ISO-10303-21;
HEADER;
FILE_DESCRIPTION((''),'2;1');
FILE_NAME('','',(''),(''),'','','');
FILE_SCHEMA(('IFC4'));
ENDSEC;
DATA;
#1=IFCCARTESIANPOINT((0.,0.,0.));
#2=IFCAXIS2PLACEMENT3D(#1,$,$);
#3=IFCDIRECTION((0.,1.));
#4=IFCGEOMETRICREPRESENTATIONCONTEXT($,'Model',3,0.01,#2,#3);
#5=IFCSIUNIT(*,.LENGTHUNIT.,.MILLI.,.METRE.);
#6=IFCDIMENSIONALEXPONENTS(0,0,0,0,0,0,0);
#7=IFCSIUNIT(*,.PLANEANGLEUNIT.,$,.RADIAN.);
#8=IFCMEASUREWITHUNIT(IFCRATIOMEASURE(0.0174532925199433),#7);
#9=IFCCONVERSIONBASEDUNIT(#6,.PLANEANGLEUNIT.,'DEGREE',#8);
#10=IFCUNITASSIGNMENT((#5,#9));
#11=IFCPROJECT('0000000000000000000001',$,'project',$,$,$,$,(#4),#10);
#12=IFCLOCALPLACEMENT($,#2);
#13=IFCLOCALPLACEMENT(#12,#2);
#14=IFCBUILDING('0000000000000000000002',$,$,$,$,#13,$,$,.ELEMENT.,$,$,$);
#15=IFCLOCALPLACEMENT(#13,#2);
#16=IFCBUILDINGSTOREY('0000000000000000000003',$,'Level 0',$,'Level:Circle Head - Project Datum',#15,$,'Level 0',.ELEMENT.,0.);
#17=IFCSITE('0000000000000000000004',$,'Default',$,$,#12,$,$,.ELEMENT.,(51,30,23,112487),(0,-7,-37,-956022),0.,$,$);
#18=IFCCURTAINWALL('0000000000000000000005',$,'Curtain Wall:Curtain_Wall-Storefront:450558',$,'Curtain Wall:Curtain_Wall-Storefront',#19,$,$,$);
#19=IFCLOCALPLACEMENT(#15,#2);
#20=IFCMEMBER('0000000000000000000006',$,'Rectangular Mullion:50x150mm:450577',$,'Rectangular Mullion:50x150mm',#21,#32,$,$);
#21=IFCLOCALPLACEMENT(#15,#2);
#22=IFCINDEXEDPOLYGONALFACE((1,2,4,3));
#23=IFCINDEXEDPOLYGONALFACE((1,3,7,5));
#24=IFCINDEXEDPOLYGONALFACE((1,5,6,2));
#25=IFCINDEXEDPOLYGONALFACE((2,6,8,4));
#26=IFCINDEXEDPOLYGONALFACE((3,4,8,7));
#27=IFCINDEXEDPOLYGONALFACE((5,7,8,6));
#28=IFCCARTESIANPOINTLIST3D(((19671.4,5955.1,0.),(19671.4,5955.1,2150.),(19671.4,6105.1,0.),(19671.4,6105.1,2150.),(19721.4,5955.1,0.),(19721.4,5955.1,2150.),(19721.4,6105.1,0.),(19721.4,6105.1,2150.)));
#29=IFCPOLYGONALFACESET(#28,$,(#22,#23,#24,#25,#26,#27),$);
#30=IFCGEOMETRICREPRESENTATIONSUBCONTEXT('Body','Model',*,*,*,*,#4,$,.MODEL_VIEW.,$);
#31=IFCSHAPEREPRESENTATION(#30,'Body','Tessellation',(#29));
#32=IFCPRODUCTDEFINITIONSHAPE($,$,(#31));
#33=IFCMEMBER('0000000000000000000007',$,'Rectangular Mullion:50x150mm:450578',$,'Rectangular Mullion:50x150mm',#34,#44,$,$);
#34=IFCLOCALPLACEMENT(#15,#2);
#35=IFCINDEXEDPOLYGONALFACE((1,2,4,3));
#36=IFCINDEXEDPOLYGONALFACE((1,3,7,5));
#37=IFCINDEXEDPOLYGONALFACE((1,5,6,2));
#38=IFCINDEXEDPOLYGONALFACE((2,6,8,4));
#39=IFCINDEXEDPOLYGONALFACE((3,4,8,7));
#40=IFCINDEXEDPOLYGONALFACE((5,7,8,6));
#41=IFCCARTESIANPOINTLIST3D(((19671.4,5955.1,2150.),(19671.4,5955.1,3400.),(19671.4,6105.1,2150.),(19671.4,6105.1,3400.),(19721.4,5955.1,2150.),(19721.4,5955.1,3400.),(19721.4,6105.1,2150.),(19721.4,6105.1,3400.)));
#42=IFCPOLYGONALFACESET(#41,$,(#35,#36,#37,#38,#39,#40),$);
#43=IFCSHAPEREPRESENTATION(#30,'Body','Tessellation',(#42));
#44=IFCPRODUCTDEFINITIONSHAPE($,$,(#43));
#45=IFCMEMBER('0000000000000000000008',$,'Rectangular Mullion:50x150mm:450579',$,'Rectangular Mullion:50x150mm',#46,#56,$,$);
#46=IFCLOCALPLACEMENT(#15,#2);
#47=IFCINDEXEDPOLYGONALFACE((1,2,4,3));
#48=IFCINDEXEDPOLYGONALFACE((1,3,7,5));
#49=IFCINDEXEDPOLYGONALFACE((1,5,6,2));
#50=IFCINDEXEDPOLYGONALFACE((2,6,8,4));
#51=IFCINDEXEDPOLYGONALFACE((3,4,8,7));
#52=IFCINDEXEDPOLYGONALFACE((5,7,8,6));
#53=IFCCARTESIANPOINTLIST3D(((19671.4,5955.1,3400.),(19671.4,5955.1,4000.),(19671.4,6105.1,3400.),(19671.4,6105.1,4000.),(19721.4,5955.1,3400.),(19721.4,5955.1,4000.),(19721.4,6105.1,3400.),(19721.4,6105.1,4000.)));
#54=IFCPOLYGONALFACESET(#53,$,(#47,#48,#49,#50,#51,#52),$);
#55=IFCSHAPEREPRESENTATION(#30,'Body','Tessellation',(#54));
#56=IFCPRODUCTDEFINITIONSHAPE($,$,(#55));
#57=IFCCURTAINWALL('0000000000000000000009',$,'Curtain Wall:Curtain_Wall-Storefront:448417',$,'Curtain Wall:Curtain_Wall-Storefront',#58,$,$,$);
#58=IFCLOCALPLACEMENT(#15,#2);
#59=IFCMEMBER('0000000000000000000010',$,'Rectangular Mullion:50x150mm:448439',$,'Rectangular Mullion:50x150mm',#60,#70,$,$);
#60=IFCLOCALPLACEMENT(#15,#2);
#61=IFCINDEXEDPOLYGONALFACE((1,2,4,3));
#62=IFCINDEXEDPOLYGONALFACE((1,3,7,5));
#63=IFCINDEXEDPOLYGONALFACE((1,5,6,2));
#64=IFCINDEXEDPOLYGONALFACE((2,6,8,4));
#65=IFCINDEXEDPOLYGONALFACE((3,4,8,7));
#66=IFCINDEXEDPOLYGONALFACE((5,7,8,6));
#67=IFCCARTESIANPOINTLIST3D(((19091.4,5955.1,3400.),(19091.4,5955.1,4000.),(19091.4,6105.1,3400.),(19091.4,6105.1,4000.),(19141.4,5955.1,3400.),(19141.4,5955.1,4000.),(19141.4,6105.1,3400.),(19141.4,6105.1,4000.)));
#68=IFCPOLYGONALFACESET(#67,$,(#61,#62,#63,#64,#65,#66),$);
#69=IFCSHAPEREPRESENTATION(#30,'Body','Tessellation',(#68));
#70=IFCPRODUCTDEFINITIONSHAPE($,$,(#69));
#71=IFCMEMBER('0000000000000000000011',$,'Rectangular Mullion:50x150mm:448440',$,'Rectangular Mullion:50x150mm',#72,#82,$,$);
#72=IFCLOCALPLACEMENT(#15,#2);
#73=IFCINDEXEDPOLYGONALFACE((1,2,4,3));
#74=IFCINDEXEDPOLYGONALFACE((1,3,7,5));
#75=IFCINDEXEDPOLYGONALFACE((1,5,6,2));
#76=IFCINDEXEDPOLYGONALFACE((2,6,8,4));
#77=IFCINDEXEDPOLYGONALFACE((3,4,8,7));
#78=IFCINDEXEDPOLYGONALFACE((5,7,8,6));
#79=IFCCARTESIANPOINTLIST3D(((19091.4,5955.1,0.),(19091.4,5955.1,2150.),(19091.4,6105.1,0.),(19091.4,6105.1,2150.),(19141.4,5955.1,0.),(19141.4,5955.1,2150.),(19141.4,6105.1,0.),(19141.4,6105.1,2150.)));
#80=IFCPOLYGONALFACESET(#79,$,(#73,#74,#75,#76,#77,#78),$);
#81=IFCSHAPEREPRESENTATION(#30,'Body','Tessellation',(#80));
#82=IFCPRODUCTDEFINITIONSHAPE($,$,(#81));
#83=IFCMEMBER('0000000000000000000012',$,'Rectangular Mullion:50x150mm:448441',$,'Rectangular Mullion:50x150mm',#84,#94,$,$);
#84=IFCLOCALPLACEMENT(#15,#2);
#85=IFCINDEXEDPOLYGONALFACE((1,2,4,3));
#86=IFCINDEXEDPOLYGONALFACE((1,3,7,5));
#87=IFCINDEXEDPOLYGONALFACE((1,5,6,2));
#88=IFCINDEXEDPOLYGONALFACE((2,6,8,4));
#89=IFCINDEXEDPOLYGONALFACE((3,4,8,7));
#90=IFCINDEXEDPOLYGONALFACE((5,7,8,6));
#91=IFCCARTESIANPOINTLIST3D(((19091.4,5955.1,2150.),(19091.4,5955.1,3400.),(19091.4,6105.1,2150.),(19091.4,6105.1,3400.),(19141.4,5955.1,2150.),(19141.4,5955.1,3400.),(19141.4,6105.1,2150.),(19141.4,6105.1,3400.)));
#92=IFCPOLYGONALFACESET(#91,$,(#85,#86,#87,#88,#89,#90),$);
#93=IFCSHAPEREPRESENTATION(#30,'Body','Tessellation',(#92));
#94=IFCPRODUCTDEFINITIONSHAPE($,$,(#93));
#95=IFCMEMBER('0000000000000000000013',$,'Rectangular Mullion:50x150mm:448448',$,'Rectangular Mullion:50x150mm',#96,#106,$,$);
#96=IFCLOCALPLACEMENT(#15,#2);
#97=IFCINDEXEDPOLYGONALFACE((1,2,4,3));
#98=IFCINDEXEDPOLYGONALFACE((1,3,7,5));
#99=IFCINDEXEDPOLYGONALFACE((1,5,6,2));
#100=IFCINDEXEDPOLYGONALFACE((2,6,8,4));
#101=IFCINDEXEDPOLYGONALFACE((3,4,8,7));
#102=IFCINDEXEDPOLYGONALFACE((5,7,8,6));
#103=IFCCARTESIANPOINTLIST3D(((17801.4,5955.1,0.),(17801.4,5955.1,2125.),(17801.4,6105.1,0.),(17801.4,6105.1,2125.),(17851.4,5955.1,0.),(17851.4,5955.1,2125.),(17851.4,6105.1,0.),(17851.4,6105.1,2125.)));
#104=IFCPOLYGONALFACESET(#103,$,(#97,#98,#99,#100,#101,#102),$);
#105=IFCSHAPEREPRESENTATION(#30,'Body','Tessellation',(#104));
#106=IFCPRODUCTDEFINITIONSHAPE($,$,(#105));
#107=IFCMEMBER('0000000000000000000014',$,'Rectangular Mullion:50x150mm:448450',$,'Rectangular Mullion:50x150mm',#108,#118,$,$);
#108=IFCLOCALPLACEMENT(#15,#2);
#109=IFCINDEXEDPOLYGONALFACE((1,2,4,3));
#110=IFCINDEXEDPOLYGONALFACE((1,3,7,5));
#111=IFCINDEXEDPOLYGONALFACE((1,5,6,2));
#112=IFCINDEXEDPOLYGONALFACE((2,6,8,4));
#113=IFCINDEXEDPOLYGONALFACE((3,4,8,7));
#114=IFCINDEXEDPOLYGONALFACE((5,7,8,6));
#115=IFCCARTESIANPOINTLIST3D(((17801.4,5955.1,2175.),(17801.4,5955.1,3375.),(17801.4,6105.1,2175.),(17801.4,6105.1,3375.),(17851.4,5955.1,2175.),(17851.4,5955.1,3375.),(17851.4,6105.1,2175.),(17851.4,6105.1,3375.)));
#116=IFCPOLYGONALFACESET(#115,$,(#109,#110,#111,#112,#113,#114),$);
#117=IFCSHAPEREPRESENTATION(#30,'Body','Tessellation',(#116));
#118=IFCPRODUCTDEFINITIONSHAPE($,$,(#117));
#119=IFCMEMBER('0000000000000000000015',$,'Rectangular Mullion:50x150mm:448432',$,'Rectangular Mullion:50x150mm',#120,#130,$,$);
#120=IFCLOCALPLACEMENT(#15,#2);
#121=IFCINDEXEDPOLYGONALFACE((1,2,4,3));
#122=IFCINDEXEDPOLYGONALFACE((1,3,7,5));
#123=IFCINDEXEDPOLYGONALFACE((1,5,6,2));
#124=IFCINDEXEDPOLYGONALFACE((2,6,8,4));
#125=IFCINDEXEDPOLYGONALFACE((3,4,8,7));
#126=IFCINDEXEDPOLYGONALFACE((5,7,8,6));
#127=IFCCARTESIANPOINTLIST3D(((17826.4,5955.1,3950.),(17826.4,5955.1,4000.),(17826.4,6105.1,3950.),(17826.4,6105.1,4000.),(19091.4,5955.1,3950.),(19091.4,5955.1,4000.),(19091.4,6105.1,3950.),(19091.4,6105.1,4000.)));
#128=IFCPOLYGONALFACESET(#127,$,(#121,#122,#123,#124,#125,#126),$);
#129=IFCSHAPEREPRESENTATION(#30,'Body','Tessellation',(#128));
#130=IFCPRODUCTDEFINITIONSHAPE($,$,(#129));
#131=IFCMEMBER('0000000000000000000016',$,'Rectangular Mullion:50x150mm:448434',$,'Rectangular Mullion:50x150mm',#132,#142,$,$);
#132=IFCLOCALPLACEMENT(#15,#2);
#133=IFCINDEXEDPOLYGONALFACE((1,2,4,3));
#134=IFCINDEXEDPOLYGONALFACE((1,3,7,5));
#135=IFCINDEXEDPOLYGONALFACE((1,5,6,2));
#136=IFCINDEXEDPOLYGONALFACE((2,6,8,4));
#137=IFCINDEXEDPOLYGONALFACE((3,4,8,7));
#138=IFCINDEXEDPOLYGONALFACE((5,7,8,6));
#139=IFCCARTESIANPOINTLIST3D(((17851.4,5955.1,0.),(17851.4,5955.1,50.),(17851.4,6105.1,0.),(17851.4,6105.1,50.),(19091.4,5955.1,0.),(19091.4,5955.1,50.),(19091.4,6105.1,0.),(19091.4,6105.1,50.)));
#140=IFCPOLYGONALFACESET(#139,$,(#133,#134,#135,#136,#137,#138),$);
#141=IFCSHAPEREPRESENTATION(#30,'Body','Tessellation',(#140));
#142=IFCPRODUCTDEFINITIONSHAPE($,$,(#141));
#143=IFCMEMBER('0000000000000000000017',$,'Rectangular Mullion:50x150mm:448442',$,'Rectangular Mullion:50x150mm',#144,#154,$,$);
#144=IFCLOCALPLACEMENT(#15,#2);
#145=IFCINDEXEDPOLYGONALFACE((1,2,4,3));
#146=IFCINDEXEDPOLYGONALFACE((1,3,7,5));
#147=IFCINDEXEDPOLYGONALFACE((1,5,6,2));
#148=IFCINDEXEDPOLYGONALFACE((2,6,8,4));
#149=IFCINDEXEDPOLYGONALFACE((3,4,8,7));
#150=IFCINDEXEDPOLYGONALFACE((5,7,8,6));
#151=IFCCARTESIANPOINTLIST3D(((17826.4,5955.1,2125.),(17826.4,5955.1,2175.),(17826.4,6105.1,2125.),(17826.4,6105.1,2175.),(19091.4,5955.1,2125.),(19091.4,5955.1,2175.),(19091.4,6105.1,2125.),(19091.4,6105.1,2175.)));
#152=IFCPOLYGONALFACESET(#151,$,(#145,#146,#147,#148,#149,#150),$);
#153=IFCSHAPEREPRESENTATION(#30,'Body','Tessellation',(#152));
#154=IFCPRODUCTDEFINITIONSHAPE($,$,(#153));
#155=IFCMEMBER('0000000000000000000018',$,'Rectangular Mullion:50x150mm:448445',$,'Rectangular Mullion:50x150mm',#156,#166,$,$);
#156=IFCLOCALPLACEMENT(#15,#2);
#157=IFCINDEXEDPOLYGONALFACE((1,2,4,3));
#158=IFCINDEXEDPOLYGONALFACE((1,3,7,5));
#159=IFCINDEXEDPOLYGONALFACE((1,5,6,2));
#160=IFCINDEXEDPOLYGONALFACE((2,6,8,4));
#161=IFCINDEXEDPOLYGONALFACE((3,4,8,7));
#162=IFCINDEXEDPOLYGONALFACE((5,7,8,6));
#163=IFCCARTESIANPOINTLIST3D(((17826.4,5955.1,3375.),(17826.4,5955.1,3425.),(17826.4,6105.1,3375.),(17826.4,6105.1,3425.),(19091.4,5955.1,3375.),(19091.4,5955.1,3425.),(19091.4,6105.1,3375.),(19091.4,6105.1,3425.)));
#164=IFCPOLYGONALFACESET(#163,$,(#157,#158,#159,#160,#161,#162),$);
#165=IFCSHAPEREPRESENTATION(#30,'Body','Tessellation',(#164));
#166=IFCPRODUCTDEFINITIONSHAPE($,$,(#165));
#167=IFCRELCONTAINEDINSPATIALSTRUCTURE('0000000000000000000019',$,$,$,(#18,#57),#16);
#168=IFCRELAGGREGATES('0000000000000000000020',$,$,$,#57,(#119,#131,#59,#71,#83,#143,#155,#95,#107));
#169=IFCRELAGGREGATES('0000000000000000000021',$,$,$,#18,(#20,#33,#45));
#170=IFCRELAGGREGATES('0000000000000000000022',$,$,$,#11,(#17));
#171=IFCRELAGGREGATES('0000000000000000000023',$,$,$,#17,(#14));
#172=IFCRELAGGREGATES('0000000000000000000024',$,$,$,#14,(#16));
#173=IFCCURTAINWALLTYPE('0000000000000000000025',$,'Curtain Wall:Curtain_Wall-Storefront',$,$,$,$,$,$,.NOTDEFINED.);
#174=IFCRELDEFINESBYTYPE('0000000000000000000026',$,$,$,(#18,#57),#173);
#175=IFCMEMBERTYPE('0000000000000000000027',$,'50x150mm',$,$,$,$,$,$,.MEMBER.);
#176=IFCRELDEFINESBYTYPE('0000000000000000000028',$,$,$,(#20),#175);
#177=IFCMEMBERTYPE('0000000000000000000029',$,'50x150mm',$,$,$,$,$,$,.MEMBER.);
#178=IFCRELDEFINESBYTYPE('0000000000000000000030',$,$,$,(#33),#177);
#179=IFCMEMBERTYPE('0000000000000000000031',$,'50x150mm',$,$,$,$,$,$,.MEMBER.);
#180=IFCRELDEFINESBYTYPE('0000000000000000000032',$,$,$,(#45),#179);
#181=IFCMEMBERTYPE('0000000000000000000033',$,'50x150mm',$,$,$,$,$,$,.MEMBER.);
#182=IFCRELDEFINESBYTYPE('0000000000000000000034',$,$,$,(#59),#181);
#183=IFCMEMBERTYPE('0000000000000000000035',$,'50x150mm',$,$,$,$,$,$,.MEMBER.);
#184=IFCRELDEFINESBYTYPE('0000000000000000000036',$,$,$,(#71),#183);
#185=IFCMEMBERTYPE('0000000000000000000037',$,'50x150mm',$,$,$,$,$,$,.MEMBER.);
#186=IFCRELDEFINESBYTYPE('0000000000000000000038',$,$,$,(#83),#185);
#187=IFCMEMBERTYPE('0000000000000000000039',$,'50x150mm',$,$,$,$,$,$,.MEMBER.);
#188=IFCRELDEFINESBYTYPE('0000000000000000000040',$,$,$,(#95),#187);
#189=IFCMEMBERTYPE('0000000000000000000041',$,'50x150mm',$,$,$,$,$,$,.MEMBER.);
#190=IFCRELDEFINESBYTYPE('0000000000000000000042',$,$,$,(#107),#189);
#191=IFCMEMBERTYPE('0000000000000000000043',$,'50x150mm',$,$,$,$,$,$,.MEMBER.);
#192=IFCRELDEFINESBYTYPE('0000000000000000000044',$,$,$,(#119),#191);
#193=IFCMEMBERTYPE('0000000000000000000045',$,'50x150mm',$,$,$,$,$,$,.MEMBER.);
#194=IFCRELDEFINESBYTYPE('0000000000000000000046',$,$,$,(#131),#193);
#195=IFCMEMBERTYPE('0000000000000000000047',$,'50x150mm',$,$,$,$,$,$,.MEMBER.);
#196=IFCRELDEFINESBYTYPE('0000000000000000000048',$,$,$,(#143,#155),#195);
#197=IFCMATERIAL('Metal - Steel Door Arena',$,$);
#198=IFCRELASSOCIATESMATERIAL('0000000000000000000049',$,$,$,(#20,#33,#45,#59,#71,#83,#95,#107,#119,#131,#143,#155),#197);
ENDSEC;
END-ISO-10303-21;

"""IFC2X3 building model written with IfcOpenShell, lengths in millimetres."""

from ifc_helpers import new_model, entity, si_unit, converted_unit, direction, frame, origin, origin_2d_with_axis, place, context, subcontext, project, spatial, rectangle, extrude, source, transform, mapped, material, type_object, type_shapes, element, aggregate, save


model = new_model("IFC2X3")

# Units and contexts
model_context = context("Model", 3, precision=0.01, world=origin(), true_north=direction((0.0, 1.0)))
body_context = subcontext(model_context, "Body", "Model", "MODEL_VIEW")
ifc_project = project(units=[si_unit("LENGTHUNIT", "METRE", prefix="MILLI"), converted_unit("PLANEANGLEUNIT", "DEGREE", entity("IfcRatioMeasure", 0.0174532925199433), si_unit("PLANEANGLEUNIT", "RADIAN"), dimensions=[0, 0, 0, 0, 0, 0, 0])], contexts=[model_context])

# Site, building, storey
site_placement = place(None, origin())
site = spatial("IfcSite", under=ifc_project, at=site_placement, Name="Default", CompositionType="ELEMENT", RefLatitude=(51, 30, 23, 112487), RefLongitude=(0, -7, -37, -956022), RefElevation=0.0)
building_placement = place(site_placement, origin())
building = spatial("IfcBuilding", under=site, at=building_placement, CompositionType="ELEMENT")
storey_placement = place(building_placement, origin())
storey = spatial("IfcBuildingStorey", under=building, at=storey_placement, Name="Level 0", ObjectType="Level:Circle Head - Project Datum", LongName="Level 0", CompositionType="ELEMENT", Elevation=0.0)

# Curtain walls, members
curtain_wall_type = type_object("IfcCurtainWallType", Name="Curtain Wall:Curtain_Wall-Storefront", PredefinedType="NOTDEFINED")
curtain_wall_1_placement = place(storey_placement, origin())
curtain_wall_1 = element("IfcCurtainWall", 1, at=curtain_wall_1_placement, inside=storey, type_object=curtain_wall_type, Name="Curtain Wall:Curtain_Wall-Storefront:450558", ObjectType="Curtain Wall:Curtain_Wall-Storefront")
ifc_material_1 = material(Name="Metal - Steel Door Arena")
member_type_1 = type_object("IfcMemberType", Name="50x150mm", PredefinedType="MEMBER")
shared_shape_1 = source(origin(), body_context, "Body", "SweptSolid", [
    extrude(rectangle(XDim=150.0, YDim=50.0, at=origin_2d_with_axis()), frame((-25.0, 0.0, -2150.0), z_axis=(0.0, 0.0, 1.0), x_axis=(0.0, -1.0, 0.0)), (0.0, 0.0, 1.0), 2150.0),
])
type_shapes(member_type_1, [shared_shape_1])
member_1_placement = place(storey_placement, frame((19671.4, 6030.1, 0.0), z_axis=(0.0, 0.0, -1.0), x_axis=(-1.0, 0.0, 0.0)))
member_1 = element("IfcMember", 2, at=member_1_placement, type_object=member_type_1, material=ifc_material_1, Name="Rectangular Mullion:50x150mm:450577", ObjectType="Rectangular Mullion:50x150mm", context=body_context, shape_type="MappedRepresentation", body=[
    mapped(shared_shape_1, transform((0.0, 0.0, 0.0), scale=1.0)),
])
member_type_2 = type_object("IfcMemberType", Name="50x150mm", PredefinedType="MEMBER")
shared_shape_2 = source(origin(), body_context, "Body", "SweptSolid", [
    extrude(rectangle(XDim=150.0, YDim=50.0, at=origin_2d_with_axis()), frame((-25.0, 0.0, -1250.0), z_axis=(0.0, 0.0, 1.0), x_axis=(0.0, -1.0, 0.0)), (0.0, 0.0, 1.0), 1250.0),
])
type_shapes(member_type_2, [shared_shape_2])
member_2_placement = place(storey_placement, frame((19671.4, 6030.1, 2150.0), z_axis=(0.0, 0.0, -1.0), x_axis=(-1.0, 0.0, 0.0)))
member_2 = element("IfcMember", 3, at=member_2_placement, type_object=member_type_2, material=ifc_material_1, Name="Rectangular Mullion:50x150mm:450578", ObjectType="Rectangular Mullion:50x150mm", context=body_context, shape_type="MappedRepresentation", body=[
    mapped(shared_shape_2, transform((0.0, 0.0, 0.0), scale=1.0)),
])
member_type_3 = type_object("IfcMemberType", Name="50x150mm", PredefinedType="MEMBER")
shared_shape_3 = source(origin(), body_context, "Body", "SweptSolid", [
    extrude(rectangle(XDim=150.0, YDim=50.0, at=origin_2d_with_axis()), frame((-25.0, 0.0, -600.0), z_axis=(0.0, 0.0, 1.0), x_axis=(0.0, -1.0, 0.0)), (0.0, 0.0, 1.0), 600.0),
])
type_shapes(member_type_3, [shared_shape_3])
member_3_placement = place(storey_placement, frame((19671.4, 6030.1, 3400.0), z_axis=(0.0, 0.0, -1.0), x_axis=(-1.0, 0.0, 0.0)))
member_3 = element("IfcMember", 4, at=member_3_placement, type_object=member_type_3, material=ifc_material_1, Name="Rectangular Mullion:50x150mm:450579", ObjectType="Rectangular Mullion:50x150mm", context=body_context, shape_type="MappedRepresentation", body=[
    mapped(shared_shape_3, transform((0.0, 0.0, 0.0), scale=1.0)),
])
curtain_wall_2_placement = place(storey_placement, origin())
curtain_wall_2 = element("IfcCurtainWall", 5, at=curtain_wall_2_placement, inside=storey, type_object=curtain_wall_type, Name="Curtain Wall:Curtain_Wall-Storefront:448417", ObjectType="Curtain Wall:Curtain_Wall-Storefront")
member_type_4 = type_object("IfcMemberType", Name="50x150mm", PredefinedType="MEMBER")
shared_shape_4 = source(origin(), body_context, "Body", "SweptSolid", [
    extrude(rectangle(XDim=150.0, YDim=50.0, at=origin_2d_with_axis()), frame((-25.0, 0.0, -600.0), z_axis=(0.0, 0.0, 1.0), x_axis=(0.0, -1.0, 0.0)), (0.0, 0.0, 1.0), 600.0),
])
type_shapes(member_type_4, [shared_shape_4])
member_4_placement = place(storey_placement, frame((19141.4, 6030.1, 4000.0)))
member_4 = element("IfcMember", 6, at=member_4_placement, type_object=member_type_4, material=ifc_material_1, Name="Rectangular Mullion:50x150mm:448439", ObjectType="Rectangular Mullion:50x150mm", context=body_context, shape_type="MappedRepresentation", body=[
    mapped(shared_shape_4, transform((0.0, 0.0, 0.0), scale=1.0)),
])
member_type_5 = type_object("IfcMemberType", Name="50x150mm", PredefinedType="MEMBER")
shared_shape_5 = source(origin(), body_context, "Body", "SweptSolid", [
    extrude(rectangle(XDim=150.0, YDim=50.0, at=origin_2d_with_axis()), frame((-25.0, 0.0, -2150.0), z_axis=(0.0, 0.0, 1.0), x_axis=(0.0, -1.0, 0.0)), (0.0, 0.0, 1.0), 2150.0),
])
type_shapes(member_type_5, [shared_shape_5])
member_5_placement = place(storey_placement, frame((19141.4, 6030.1, 2150.0)))
member_5 = element("IfcMember", 7, at=member_5_placement, type_object=member_type_5, material=ifc_material_1, Name="Rectangular Mullion:50x150mm:448440", ObjectType="Rectangular Mullion:50x150mm", context=body_context, shape_type="MappedRepresentation", body=[
    mapped(shared_shape_5, transform((0.0, 0.0, 0.0), scale=1.0)),
])
member_type_6 = type_object("IfcMemberType", Name="50x150mm", PredefinedType="MEMBER")
shared_shape_6 = source(origin(), body_context, "Body", "SweptSolid", [
    extrude(rectangle(XDim=150.0, YDim=50.0, at=origin_2d_with_axis()), frame((-25.0, 0.0, -1250.0), z_axis=(0.0, 0.0, 1.0), x_axis=(0.0, -1.0, 0.0)), (0.0, 0.0, 1.0), 1250.0),
])
type_shapes(member_type_6, [shared_shape_6])
member_6_placement = place(storey_placement, frame((19141.4, 6030.1, 3400.0)))
member_6 = element("IfcMember", 8, at=member_6_placement, type_object=member_type_6, material=ifc_material_1, Name="Rectangular Mullion:50x150mm:448441", ObjectType="Rectangular Mullion:50x150mm", context=body_context, shape_type="MappedRepresentation", body=[
    mapped(shared_shape_6, transform((0.0, 0.0, 0.0), scale=1.0)),
])
member_type_7 = type_object("IfcMemberType", Name="50x150mm", PredefinedType="MEMBER")
shared_shape_7 = source(origin(), body_context, "Body", "SweptSolid", [
    extrude(rectangle(XDim=150.0, YDim=50.0, at=origin_2d_with_axis()), frame((0.0, 0.0, -2125.0), z_axis=(0.0, 0.0, 1.0), x_axis=(0.0, -1.0, 0.0)), (0.0, 0.0, 1.0), 2125.0),
])
type_shapes(member_type_7, [shared_shape_7])
member_7_placement = place(storey_placement, frame((17826.4, 6030.1, 0.0), z_axis=(0.0, 0.0, -1.0), x_axis=(-1.0, 0.0, 0.0)))
member_7 = element("IfcMember", 9, at=member_7_placement, type_object=member_type_7, material=ifc_material_1, Name="Rectangular Mullion:50x150mm:448448", ObjectType="Rectangular Mullion:50x150mm", context=body_context, shape_type="MappedRepresentation", body=[
    mapped(shared_shape_7, transform((0.0, 0.0, 0.0), scale=1.0)),
])
member_type_8 = type_object("IfcMemberType", Name="50x150mm", PredefinedType="MEMBER")
shared_shape_8 = source(origin(), body_context, "Body", "SweptSolid", [
    extrude(rectangle(XDim=150.0, YDim=50.0, at=origin_2d_with_axis()), frame((0.0, 0.0, -1200.0), z_axis=(0.0, 0.0, 1.0), x_axis=(0.0, -1.0, 0.0)), (0.0, 0.0, 1.0), 1200.0),
])
type_shapes(member_type_8, [shared_shape_8])
member_8_placement = place(storey_placement, frame((17826.4, 6030.1, 2175.0), z_axis=(0.0, 0.0, -1.0), x_axis=(-1.0, 0.0, 0.0)))
member_8 = element("IfcMember", 10, at=member_8_placement, type_object=member_type_8, material=ifc_material_1, Name="Rectangular Mullion:50x150mm:448450", ObjectType="Rectangular Mullion:50x150mm", context=body_context, shape_type="MappedRepresentation", body=[
    mapped(shared_shape_8, transform((0.0, 0.0, 0.0), scale=1.0)),
])
member_type_9 = type_object("IfcMemberType", Name="50x150mm", PredefinedType="MEMBER")
shared_shape_9 = source(origin(), body_context, "Body", "SweptSolid", [
    extrude(rectangle(XDim=150.0, YDim=50.0, at=origin_2d_with_axis()), frame((-25.0, 0.0, -1265.0), z_axis=(0.0, 0.0, 1.0), x_axis=(0.0, -1.0, 0.0)), (0.0, 0.0, 1.0), 1265.0),
])
type_shapes(member_type_9, [shared_shape_9])
member_9_placement = place(storey_placement, frame((17826.4, 6030.1, 4000.0), z_axis=(-1.0, 0.0, 0.0), x_axis=(0.0, 0.0, 1.0)))
member_9 = element("IfcMember", 11, at=member_9_placement, type_object=member_type_9, material=ifc_material_1, Name="Rectangular Mullion:50x150mm:448432", ObjectType="Rectangular Mullion:50x150mm", context=body_context, shape_type="MappedRepresentation", body=[
    mapped(shared_shape_9, transform((0.0, 0.0, 0.0), scale=1.0)),
])
member_type_10 = type_object("IfcMemberType", Name="50x150mm", PredefinedType="MEMBER")
shared_shape_10 = source(origin(), body_context, "Body", "SweptSolid", [
    extrude(rectangle(XDim=150.0, YDim=50.0, at=origin_2d_with_axis()), frame((-25.0, 0.0, -1240.0), z_axis=(0.0, 0.0, 1.0), x_axis=(0.0, -1.0, 0.0)), (0.0, 0.0, 1.0), 1240.0),
])
type_shapes(member_type_10, [shared_shape_10])
member_10_placement = place(storey_placement, frame((19091.4, 6030.1, 0.0), z_axis=(1.0, 0.0, 0.0), x_axis=(0.0, 0.0, -1.0)))
member_10 = element("IfcMember", 12, at=member_10_placement, type_object=member_type_10, material=ifc_material_1, Name="Rectangular Mullion:50x150mm:448434", ObjectType="Rectangular Mullion:50x150mm", context=body_context, shape_type="MappedRepresentation", body=[
    mapped(shared_shape_10, transform((0.0, 0.0, 0.0), scale=1.0)),
])
member_type_11 = type_object("IfcMemberType", Name="50x150mm", PredefinedType="MEMBER")
shared_shape_11 = source(origin(), body_context, "Body", "SweptSolid", [
    extrude(rectangle(XDim=150.0, YDim=50.0, at=origin_2d_with_axis()), frame((0.0, 0.0, -1265.0), z_axis=(0.0, 0.0, 1.0), x_axis=(0.0, -1.0, 0.0)), (0.0, 0.0, 1.0), 1265.0),
])
type_shapes(member_type_11, [shared_shape_11])
member_11_placement = place(storey_placement, frame((17826.4, 6030.1, 2150.0), z_axis=(-1.0, 0.0, 0.0), x_axis=(0.0, 0.0, 1.0)))
member_11 = element("IfcMember", 13, at=member_11_placement, type_object=member_type_11, material=ifc_material_1, Name="Rectangular Mullion:50x150mm:448442", ObjectType="Rectangular Mullion:50x150mm", context=body_context, shape_type="MappedRepresentation", body=[
    mapped(shared_shape_11, transform((0.0, 0.0, 0.0), scale=1.0)),
])
member_12_placement = place(storey_placement, frame((17826.4, 6030.1, 3400.0), z_axis=(-1.0, 0.0, 0.0), x_axis=(0.0, 0.0, 1.0)))
member_12 = element("IfcMember", 14, at=member_12_placement, type_object=member_type_11, material=ifc_material_1, Name="Rectangular Mullion:50x150mm:448445", ObjectType="Rectangular Mullion:50x150mm", context=body_context, shape_type="MappedRepresentation", body=[
    mapped(shared_shape_11, transform((0.0, 0.0, 0.0), scale=1.0)),
])

aggregate(curtain_wall_2, [member_9, member_10, member_4, member_5, member_6, member_11, member_12, member_7, member_8])
aggregate(curtain_wall_1, [member_1, member_2, member_3])

save(model, "model.ifc")
